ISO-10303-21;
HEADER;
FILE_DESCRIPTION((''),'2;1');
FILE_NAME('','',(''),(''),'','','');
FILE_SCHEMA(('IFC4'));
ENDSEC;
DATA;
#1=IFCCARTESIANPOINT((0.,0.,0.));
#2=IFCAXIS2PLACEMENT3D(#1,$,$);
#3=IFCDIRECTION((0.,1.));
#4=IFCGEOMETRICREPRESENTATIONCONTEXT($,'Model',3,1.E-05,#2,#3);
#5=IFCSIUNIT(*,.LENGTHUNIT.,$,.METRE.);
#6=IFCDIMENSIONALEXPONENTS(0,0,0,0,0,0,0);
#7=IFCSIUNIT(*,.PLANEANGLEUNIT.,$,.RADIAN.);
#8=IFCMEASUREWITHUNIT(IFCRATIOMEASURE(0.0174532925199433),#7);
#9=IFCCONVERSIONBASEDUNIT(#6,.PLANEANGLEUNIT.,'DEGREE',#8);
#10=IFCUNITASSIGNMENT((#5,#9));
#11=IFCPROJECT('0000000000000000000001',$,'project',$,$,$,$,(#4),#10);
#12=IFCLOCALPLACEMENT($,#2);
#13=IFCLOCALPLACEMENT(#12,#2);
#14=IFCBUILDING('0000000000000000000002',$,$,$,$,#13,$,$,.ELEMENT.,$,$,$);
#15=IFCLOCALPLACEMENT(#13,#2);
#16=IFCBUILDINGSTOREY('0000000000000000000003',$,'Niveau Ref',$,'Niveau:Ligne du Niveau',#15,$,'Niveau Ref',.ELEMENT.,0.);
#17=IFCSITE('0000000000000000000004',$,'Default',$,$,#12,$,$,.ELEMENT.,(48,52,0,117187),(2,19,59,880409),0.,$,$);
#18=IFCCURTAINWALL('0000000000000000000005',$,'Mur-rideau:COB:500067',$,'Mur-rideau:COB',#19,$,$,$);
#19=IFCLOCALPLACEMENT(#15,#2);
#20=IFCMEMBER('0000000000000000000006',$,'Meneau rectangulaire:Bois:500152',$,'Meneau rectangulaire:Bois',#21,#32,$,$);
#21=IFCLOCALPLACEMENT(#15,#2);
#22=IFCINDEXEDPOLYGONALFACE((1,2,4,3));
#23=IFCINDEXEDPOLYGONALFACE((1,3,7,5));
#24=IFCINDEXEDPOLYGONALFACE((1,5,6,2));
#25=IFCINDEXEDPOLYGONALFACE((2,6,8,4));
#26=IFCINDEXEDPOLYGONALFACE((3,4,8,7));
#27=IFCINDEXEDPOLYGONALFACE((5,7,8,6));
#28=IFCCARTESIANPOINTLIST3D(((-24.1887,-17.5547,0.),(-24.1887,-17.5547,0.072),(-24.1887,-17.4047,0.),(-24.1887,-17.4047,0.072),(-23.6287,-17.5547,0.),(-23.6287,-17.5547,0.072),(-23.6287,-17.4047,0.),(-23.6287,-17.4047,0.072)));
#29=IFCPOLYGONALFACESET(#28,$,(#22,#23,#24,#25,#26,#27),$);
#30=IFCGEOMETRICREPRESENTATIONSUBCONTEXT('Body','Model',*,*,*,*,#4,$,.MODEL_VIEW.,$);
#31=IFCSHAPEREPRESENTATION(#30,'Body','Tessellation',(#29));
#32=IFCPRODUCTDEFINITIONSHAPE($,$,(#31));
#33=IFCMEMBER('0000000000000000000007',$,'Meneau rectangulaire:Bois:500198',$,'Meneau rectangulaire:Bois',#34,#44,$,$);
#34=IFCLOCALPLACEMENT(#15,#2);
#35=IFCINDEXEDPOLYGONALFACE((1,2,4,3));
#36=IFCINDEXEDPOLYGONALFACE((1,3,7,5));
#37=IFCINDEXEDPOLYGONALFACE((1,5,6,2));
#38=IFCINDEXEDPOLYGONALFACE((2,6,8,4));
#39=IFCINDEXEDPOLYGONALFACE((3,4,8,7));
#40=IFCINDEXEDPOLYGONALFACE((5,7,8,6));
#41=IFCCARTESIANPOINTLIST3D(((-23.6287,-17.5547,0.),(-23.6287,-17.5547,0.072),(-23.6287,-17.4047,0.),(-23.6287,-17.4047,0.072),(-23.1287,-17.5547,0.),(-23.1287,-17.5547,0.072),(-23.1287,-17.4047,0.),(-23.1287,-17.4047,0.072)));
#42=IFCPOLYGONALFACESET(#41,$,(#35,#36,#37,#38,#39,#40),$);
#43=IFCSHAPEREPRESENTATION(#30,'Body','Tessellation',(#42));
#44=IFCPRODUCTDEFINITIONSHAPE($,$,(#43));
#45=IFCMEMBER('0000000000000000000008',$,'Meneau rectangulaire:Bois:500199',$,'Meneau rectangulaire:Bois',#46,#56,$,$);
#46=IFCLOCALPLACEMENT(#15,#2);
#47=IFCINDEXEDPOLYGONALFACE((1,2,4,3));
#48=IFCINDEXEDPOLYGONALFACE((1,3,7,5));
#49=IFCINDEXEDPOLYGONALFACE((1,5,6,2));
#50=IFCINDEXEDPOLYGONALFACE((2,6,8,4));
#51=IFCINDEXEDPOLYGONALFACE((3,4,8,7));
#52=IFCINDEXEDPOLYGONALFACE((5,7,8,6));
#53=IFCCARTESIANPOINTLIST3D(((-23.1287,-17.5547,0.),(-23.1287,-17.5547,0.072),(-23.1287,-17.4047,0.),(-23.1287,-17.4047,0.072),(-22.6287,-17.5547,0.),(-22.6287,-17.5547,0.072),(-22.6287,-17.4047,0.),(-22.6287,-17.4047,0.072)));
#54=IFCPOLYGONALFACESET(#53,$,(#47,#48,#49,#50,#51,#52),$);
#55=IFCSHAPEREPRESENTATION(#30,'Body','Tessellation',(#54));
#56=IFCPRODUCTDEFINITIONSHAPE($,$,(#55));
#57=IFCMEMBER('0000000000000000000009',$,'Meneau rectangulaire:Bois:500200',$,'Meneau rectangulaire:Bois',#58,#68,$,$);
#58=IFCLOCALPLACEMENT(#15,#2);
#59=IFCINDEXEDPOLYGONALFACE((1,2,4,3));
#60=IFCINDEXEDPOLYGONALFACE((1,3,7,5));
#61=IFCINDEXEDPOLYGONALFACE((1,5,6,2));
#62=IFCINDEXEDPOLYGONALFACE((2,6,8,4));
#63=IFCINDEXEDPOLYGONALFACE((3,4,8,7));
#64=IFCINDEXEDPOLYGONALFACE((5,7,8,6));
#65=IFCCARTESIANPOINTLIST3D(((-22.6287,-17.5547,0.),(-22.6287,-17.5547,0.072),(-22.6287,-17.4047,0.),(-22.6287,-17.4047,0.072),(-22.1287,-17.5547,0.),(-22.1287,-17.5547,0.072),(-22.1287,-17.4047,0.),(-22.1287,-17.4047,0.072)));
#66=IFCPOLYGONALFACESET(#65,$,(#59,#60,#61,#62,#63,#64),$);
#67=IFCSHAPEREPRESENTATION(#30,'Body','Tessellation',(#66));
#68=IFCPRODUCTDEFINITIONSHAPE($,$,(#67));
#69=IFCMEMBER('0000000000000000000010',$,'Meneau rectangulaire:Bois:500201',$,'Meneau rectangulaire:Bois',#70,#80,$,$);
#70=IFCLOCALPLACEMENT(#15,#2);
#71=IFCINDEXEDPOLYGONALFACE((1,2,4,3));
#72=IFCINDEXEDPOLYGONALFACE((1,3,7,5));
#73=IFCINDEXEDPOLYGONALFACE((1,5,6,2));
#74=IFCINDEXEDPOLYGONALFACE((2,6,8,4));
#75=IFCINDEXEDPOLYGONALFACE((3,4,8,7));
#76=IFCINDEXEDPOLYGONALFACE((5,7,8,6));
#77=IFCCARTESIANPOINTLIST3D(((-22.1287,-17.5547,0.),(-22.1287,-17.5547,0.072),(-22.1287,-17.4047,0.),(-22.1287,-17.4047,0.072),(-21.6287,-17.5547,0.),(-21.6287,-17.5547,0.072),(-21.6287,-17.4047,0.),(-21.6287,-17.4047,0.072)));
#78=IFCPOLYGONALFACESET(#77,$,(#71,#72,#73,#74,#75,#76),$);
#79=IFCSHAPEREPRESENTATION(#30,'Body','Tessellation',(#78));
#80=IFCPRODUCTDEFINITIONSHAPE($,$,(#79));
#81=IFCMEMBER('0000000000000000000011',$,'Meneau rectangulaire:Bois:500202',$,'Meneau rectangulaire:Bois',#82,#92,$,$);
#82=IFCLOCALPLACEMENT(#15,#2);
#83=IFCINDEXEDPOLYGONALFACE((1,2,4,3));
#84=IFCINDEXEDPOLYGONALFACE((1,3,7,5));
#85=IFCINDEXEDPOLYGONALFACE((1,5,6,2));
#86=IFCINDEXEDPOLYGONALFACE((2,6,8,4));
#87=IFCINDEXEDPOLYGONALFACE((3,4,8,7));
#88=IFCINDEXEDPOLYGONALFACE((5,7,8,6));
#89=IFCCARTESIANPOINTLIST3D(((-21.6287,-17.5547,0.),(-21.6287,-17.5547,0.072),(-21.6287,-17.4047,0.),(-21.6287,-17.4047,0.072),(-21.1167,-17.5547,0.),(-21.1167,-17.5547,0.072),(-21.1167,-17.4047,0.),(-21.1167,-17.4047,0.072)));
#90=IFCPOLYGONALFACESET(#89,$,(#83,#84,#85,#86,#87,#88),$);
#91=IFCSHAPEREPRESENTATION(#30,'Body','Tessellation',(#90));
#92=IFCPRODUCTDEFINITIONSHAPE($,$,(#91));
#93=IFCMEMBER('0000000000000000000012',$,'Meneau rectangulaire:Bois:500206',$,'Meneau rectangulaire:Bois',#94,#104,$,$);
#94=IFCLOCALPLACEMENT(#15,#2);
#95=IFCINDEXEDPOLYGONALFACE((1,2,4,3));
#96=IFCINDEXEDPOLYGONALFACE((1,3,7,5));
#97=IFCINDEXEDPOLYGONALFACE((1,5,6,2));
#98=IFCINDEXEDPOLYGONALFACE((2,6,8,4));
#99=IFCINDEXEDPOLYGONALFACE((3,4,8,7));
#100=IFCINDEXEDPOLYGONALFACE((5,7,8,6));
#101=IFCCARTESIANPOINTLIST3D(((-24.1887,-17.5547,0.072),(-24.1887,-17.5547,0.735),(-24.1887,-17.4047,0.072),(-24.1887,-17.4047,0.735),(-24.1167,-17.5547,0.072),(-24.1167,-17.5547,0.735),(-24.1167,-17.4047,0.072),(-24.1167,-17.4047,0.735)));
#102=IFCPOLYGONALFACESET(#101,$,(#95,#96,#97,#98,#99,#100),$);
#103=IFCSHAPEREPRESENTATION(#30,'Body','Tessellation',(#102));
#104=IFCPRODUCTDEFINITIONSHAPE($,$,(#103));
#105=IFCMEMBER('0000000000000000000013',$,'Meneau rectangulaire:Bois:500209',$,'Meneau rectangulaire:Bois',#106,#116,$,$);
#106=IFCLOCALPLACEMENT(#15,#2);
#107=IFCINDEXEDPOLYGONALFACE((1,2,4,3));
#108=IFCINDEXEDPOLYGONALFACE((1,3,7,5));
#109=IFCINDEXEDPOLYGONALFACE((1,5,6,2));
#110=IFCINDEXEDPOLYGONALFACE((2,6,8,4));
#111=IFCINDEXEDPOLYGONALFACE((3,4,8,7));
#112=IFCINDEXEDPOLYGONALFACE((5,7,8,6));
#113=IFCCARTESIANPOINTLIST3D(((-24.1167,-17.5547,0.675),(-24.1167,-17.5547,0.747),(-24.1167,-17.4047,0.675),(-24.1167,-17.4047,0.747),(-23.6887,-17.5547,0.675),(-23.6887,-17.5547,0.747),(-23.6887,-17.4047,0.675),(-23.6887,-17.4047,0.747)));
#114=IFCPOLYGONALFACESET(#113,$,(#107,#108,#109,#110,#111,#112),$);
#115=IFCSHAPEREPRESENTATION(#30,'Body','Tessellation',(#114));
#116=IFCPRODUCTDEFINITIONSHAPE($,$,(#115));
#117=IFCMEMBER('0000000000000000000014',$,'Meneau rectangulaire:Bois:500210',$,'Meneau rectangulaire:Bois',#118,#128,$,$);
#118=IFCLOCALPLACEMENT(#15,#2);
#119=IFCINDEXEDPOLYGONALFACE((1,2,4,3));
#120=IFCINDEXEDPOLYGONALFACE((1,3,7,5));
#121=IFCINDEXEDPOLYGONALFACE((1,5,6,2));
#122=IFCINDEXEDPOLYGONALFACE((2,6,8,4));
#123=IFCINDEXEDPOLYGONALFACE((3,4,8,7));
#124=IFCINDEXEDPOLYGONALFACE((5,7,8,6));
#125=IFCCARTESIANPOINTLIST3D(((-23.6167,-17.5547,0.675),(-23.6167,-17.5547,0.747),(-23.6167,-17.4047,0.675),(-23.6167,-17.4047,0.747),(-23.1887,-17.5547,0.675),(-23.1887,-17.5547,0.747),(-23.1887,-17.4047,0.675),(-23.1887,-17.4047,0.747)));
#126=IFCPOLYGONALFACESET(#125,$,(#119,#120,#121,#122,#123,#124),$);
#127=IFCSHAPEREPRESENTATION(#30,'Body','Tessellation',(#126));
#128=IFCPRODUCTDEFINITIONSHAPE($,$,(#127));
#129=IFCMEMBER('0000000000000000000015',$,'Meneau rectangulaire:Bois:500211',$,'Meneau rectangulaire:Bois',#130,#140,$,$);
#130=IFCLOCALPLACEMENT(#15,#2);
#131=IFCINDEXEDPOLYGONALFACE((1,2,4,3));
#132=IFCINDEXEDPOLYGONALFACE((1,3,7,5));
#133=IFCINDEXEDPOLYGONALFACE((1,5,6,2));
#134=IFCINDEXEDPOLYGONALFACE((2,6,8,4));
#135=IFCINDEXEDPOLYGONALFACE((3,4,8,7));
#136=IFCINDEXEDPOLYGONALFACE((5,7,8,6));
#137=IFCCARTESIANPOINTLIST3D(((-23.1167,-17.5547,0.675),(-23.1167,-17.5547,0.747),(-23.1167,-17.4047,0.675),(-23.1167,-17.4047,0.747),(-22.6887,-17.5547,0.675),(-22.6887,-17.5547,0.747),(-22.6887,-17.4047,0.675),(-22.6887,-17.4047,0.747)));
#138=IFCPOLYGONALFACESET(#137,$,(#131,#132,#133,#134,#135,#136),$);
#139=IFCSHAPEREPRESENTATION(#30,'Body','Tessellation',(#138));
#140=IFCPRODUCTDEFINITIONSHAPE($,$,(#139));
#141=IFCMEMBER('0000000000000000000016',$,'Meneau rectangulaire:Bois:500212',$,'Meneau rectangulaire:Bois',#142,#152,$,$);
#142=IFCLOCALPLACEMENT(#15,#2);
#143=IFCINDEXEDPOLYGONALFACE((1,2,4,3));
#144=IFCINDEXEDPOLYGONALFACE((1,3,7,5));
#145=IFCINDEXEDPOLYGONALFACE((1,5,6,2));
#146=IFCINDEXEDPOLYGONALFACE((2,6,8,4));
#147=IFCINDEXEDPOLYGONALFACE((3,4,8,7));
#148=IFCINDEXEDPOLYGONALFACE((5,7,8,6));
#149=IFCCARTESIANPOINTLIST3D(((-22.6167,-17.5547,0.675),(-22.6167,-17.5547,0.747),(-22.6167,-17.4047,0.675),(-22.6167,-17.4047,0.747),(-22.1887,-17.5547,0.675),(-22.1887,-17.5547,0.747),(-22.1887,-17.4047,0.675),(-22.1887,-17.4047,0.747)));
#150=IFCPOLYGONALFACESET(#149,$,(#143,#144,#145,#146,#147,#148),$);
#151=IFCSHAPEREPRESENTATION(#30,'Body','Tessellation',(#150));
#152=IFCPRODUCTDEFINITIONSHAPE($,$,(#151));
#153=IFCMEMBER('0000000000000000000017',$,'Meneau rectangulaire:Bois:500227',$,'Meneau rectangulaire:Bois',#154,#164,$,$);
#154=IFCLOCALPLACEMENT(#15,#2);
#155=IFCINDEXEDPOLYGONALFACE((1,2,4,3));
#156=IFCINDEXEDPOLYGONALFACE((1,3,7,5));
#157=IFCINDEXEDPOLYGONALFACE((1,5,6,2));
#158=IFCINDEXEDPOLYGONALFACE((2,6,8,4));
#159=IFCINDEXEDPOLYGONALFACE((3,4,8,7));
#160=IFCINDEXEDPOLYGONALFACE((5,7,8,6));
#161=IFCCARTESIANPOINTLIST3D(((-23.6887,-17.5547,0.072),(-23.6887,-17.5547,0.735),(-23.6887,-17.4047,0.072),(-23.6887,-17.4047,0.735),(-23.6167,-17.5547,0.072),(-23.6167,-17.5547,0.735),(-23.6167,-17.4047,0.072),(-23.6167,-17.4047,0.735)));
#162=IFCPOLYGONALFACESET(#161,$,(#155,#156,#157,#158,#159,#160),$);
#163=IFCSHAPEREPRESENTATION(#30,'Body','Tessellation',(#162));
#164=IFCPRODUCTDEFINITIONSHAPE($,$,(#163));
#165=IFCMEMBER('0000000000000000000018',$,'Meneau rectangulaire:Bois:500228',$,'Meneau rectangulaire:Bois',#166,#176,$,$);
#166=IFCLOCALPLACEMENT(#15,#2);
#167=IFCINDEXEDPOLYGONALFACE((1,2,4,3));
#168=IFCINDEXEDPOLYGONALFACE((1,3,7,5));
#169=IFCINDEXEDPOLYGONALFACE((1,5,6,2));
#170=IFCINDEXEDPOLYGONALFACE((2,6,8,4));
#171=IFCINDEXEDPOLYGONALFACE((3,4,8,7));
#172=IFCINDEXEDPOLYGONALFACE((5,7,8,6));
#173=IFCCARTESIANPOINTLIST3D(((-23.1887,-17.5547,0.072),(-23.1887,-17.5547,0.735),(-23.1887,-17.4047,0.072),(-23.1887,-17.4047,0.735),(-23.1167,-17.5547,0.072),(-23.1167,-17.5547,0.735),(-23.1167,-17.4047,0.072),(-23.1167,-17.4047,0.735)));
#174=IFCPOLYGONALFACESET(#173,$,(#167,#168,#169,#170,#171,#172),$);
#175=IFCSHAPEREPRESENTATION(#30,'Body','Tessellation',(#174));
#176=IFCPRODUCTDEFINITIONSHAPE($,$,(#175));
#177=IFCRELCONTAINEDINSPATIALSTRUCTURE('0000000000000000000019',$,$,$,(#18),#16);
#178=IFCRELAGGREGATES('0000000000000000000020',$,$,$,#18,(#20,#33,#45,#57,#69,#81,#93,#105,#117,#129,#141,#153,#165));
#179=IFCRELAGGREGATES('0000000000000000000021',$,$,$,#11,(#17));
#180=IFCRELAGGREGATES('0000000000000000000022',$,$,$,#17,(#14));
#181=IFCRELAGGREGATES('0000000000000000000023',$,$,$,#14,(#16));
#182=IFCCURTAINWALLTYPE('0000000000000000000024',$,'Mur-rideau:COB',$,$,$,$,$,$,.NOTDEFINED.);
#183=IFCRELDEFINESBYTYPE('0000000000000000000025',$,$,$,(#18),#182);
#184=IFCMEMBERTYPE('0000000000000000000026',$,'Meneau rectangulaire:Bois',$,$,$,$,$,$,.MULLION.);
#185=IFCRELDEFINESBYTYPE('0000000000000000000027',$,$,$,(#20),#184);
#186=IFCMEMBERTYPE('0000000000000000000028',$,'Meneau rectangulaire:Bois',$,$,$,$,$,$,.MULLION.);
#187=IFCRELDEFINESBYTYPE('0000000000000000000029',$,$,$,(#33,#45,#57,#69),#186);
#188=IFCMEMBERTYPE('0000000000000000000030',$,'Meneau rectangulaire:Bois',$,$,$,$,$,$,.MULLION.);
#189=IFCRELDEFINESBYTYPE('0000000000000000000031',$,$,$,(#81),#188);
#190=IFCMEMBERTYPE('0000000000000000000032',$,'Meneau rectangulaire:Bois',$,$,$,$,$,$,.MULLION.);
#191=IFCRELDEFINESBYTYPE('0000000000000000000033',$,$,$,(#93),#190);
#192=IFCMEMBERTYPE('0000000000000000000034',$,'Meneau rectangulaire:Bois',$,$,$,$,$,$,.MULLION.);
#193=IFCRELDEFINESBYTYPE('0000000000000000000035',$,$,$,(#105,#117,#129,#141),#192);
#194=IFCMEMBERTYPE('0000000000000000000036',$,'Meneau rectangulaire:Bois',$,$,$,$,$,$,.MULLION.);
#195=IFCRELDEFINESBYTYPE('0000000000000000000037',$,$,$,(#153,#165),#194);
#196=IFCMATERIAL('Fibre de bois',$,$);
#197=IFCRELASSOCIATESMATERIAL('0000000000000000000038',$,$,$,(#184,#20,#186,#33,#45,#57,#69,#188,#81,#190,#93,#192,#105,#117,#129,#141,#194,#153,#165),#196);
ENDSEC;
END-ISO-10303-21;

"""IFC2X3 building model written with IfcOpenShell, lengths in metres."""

from ifc_helpers import new_model, entity, si_unit, converted_unit, direction, frame, origin, origin_2d_with_axis, place, context, subcontext, project, spatial, rectangle, extrude, source, transform, mapped, material, type_object, type_shapes, element, aggregate, save


model = new_model("IFC2X3")

# Units and contexts
model_context = context("Model", 3, precision=1e-05, world=origin(), true_north=direction((0.0, 1.0)))
body_context = subcontext(model_context, "Body", "Model", "MODEL_VIEW")
ifc_project = project(units=[si_unit("LENGTHUNIT", "METRE"), converted_unit("PLANEANGLEUNIT", "DEGREE", entity("IfcRatioMeasure", 0.0174532925199433), si_unit("PLANEANGLEUNIT", "RADIAN"), dimensions=[0, 0, 0, 0, 0, 0, 0])], contexts=[model_context])

# Site, building, storey
site_placement = place(None, origin())
site = spatial("IfcSite", under=ifc_project, at=site_placement, Name="Default", CompositionType="ELEMENT", RefLatitude=(48, 52, 0, 117187), RefLongitude=(2, 19, 59, 880409), RefElevation=0.0)
building_placement = place(site_placement, origin())
building = spatial("IfcBuilding", under=site, at=building_placement, CompositionType="ELEMENT")
storey_placement = place(building_placement, origin())
storey = spatial("IfcBuildingStorey", under=building, at=storey_placement, Name="Niveau Ref", ObjectType="Niveau:Ligne du Niveau", LongName="Niveau Ref", CompositionType="ELEMENT", Elevation=0.0)

# Curtain wall, members
curtain_wall_type_1 = type_object("IfcCurtainWallType", Name="Mur-rideau:COB", PredefinedType="NOTDEFINED")
curtain_wall_1_placement = place(storey_placement, origin())
curtain_wall_1 = element("IfcCurtainWall", 1, at=curtain_wall_1_placement, inside=storey, type_object=curtain_wall_type_1, Name="Mur-rideau:COB:500067", ObjectType="Mur-rideau:COB")
ifc_material_1 = material(Name="Fibre de bois")
member_type_1 = type_object("IfcMemberType", Name="Meneau rectangulaire:Bois", PredefinedType="MULLION", material=ifc_material_1)
shared_shape_1 = source(origin(), body_context, "Body", "SweptSolid", [
    extrude(rectangle(XDim=0.15, YDim=0.072, at=origin_2d_with_axis()), frame((-0.036, 0.0, -0.56), z_axis=(0.0, 0.0, 1.0), x_axis=(0.0, -1.0, 0.0)), (0.0, 0.0, 1.0), 0.56),
])
type_shapes(member_type_1, [shared_shape_1])
member_1_placement = place(storey_placement, frame((-24.1887, -17.4797, 0.0), z_axis=(-1.0, 0.0, 0.0), x_axis=(0.0, 0.0, -1.0)))
member_1 = element("IfcMember", 2, at=member_1_placement, type_object=member_type_1, material=ifc_material_1, Name="Meneau rectangulaire:Bois:500152", ObjectType="Meneau rectangulaire:Bois", context=body_context, shape_type="MappedRepresentation", body=[
    mapped(shared_shape_1, transform((0.0, 0.0, 0.0), scale=1.0)),
])
member_type_2 = type_object("IfcMemberType", Name="Meneau rectangulaire:Bois", PredefinedType="MULLION", material=ifc_material_1)
shared_shape_2 = source(origin(), body_context, "Body", "SweptSolid", [
    extrude(rectangle(XDim=0.15, YDim=0.072, at=origin_2d_with_axis()), frame((-0.036, 0.0, -0.5), z_axis=(0.0, 0.0, 1.0), x_axis=(0.0, -1.0, 0.0)), (0.0, 0.0, 1.0), 0.5),
])
type_shapes(member_type_2, [shared_shape_2])
member_2_placement = place(storey_placement, frame((-23.6287, -17.4797, 0.0), z_axis=(-1.0, 0.0, 0.0), x_axis=(0.0, 0.0, -1.0)))
member_2 = element("IfcMember", 3, at=member_2_placement, type_object=member_type_2, material=ifc_material_1, Name="Meneau rectangulaire:Bois:500198", ObjectType="Meneau rectangulaire:Bois", context=body_context, shape_type="MappedRepresentation", body=[
    mapped(shared_shape_2, transform((0.0, 0.0, 0.0), scale=1.0)),
])
member_3_placement = place(storey_placement, frame((-23.1287, -17.4797, 0.0), z_axis=(-1.0, 0.0, 0.0), x_axis=(0.0, 0.0, -1.0)))
member_3 = element("IfcMember", 4, at=member_3_placement, type_object=member_type_2, material=ifc_material_1, Name="Meneau rectangulaire:Bois:500199", ObjectType="Meneau rectangulaire:Bois", context=body_context, shape_type="MappedRepresentation", body=[
    mapped(shared_shape_2, transform((0.0, 0.0, 0.0), scale=1.0)),
])
member_4_placement = place(storey_placement, frame((-22.6287, -17.4797, 0.0), z_axis=(-1.0, 0.0, 0.0), x_axis=(0.0, 0.0, -1.0)))
member_4 = element("IfcMember", 5, at=member_4_placement, type_object=member_type_2, material=ifc_material_1, Name="Meneau rectangulaire:Bois:500200", ObjectType="Meneau rectangulaire:Bois", context=body_context, shape_type="MappedRepresentation", body=[
    mapped(shared_shape_2, transform((0.0, 0.0, 0.0), scale=1.0)),
])
member_5_placement = place(storey_placement, frame((-22.1287, -17.4797, 0.0), z_axis=(-1.0, 0.0, 0.0), x_axis=(0.0, 0.0, -1.0)))
member_5 = element("IfcMember", 6, at=member_5_placement, type_object=member_type_2, material=ifc_material_1, Name="Meneau rectangulaire:Bois:500201", ObjectType="Meneau rectangulaire:Bois", context=body_context, shape_type="MappedRepresentation", body=[
    mapped(shared_shape_2, transform((0.0, 0.0, 0.0), scale=1.0)),
])
member_type_3 = type_object("IfcMemberType", Name="Meneau rectangulaire:Bois", PredefinedType="MULLION", material=ifc_material_1)
shared_shape_3 = source(origin(), body_context, "Body", "SweptSolid", [
    extrude(rectangle(XDim=0.15, YDim=0.072, at=origin_2d_with_axis()), frame((-0.036, 0.0, -0.512), z_axis=(0.0, 0.0, 1.0), x_axis=(0.0, -1.0, 0.0)), (0.0, 0.0, 1.0), 0.512),
])
type_shapes(member_type_3, [shared_shape_3])
member_6_placement = place(storey_placement, frame((-21.6287, -17.4797, 0.0), z_axis=(-1.0, 0.0, 0.0), x_axis=(0.0, 0.0, -1.0)))
member_6 = element("IfcMember", 7, at=member_6_placement, type_object=member_type_3, material=ifc_material_1, Name="Meneau rectangulaire:Bois:500202", ObjectType="Meneau rectangulaire:Bois", context=body_context, shape_type="MappedRepresentation", body=[
    mapped(shared_shape_3, transform((0.0, 0.0, 0.0), scale=1.0)),
])
member_type_4 = type_object("IfcMemberType", Name="Meneau rectangulaire:Bois", PredefinedType="MULLION", material=ifc_material_1)
shared_shape_4 = source(origin(), body_context, "Body", "SweptSolid", [
    extrude(rectangle(XDim=0.15, YDim=0.072, at=origin_2d_with_axis()), frame((-0.036, 0.0, -0.663), z_axis=(0.0, 0.0, 1.0), x_axis=(0.0, -1.0, 0.0)), (0.0, 0.0, 1.0), 0.663),
])
type_shapes(member_type_4, [shared_shape_4])
member_7_placement = place(storey_placement, frame((-24.1887, -17.4797, 0.735), z_axis=(0.0, 0.0, 1.0), x_axis=(-1.0, 0.0, 0.0)))
member_7 = element("IfcMember", 8, at=member_7_placement, type_object=member_type_4, material=ifc_material_1, Name="Meneau rectangulaire:Bois:500206", ObjectType="Meneau rectangulaire:Bois", context=body_context, shape_type="MappedRepresentation", body=[
    mapped(shared_shape_4, transform((0.0, 0.0, 0.0), scale=1.0)),
])
member_type_5 = type_object("IfcMemberType", Name="Meneau rectangulaire:Bois", PredefinedType="MULLION", material=ifc_material_1)
shared_shape_5 = source(origin(), body_context, "Body", "SweptSolid", [
    extrude(rectangle(XDim=0.15, YDim=0.072, at=origin_2d_with_axis()), frame((-0.024, 0.0, -0.428), z_axis=(0.0, 0.0, 1.0), x_axis=(0.0, -1.0, 0.0)), (0.0, 0.0, 1.0), 0.428),
])
type_shapes(member_type_5, [shared_shape_5])
member_8_placement = place(storey_placement, frame((-23.6887, -17.4797, 0.735), z_axis=(1.0, 0.0, 0.0), x_axis=(0.0, 0.0, 1.0)))
member_8 = element("IfcMember", 9, at=member_8_placement, type_object=member_type_5, material=ifc_material_1, Name="Meneau rectangulaire:Bois:500209", ObjectType="Meneau rectangulaire:Bois", context=body_context, shape_type="MappedRepresentation", body=[
    mapped(shared_shape_5, transform((0.0, 0.0, 0.0), scale=1.0)),
])
member_9_placement = place(storey_placement, frame((-23.1887, -17.4797, 0.735), z_axis=(1.0, 0.0, 0.0), x_axis=(0.0, 0.0, 1.0)))
member_9 = element("IfcMember", 10, at=member_9_placement, type_object=member_type_5, material=ifc_material_1, Name="Meneau rectangulaire:Bois:500210", ObjectType="Meneau rectangulaire:Bois", context=body_context, shape_type="MappedRepresentation", body=[
    mapped(shared_shape_5, transform((0.0, 0.0, 0.0), scale=1.0)),
])
member_10_placement = place(storey_placement, frame((-22.6887, -17.4797, 0.735), z_axis=(1.0, 0.0, 0.0), x_axis=(0.0, 0.0, 1.0)))
member_10 = element("IfcMember", 11, at=member_10_placement, type_object=member_type_5, material=ifc_material_1, Name="Meneau rectangulaire:Bois:500211", ObjectType="Meneau rectangulaire:Bois", context=body_context, shape_type="MappedRepresentation", body=[
    mapped(shared_shape_5, transform((0.0, 0.0, 0.0), scale=1.0)),
])
member_11_placement = place(storey_placement, frame((-22.1887, -17.4797, 0.735), z_axis=(1.0, 0.0, 0.0), x_axis=(0.0, 0.0, 1.0)))
member_11 = element("IfcMember", 12, at=member_11_placement, type_object=member_type_5, material=ifc_material_1, Name="Meneau rectangulaire:Bois:500212", ObjectType="Meneau rectangulaire:Bois", context=body_context, shape_type="MappedRepresentation", body=[
    mapped(shared_shape_5, transform((0.0, 0.0, 0.0), scale=1.0)),
])
member_type_6 = type_object("IfcMemberType", Name="Meneau rectangulaire:Bois", PredefinedType="MULLION", material=ifc_material_1)
shared_shape_6 = source(origin(), body_context, "Body", "SweptSolid", [
    extrude(rectangle(XDim=0.15, YDim=0.072, at=origin_2d_with_axis()), frame((-0.024, 0.0, -0.663), z_axis=(0.0, 0.0, 1.0), x_axis=(0.0, -1.0, 0.0)), (0.0, 0.0, 1.0), 0.663),
])
type_shapes(member_type_6, [shared_shape_6])
member_12_placement = place(storey_placement, frame((-23.6287, -17.4797, 0.072), z_axis=(0.0, 0.0, -1.0), x_axis=(1.0, 0.0, 0.0)))
member_12 = element("IfcMember", 13, at=member_12_placement, type_object=member_type_6, material=ifc_material_1, Name="Meneau rectangulaire:Bois:500227", ObjectType="Meneau rectangulaire:Bois", context=body_context, shape_type="MappedRepresentation", body=[
    mapped(shared_shape_6, transform((0.0, 0.0, 0.0), scale=1.0)),
])
member_13_placement = place(storey_placement, frame((-23.1287, -17.4797, 0.072), z_axis=(0.0, 0.0, -1.0), x_axis=(1.0, 0.0, 0.0)))
member_13 = element("IfcMember", 14, at=member_13_placement, type_object=member_type_6, material=ifc_material_1, Name="Meneau rectangulaire:Bois:500228", ObjectType="Meneau rectangulaire:Bois", context=body_context, shape_type="MappedRepresentation", body=[
    mapped(shared_shape_6, transform((0.0, 0.0, 0.0), scale=1.0)),
])
aggregate(curtain_wall_1, [member_1, member_2, member_3, member_4, member_5, member_6, member_7, member_8, member_9, member_10, member_11, member_12, member_13])

save(model, "model.ifc")
